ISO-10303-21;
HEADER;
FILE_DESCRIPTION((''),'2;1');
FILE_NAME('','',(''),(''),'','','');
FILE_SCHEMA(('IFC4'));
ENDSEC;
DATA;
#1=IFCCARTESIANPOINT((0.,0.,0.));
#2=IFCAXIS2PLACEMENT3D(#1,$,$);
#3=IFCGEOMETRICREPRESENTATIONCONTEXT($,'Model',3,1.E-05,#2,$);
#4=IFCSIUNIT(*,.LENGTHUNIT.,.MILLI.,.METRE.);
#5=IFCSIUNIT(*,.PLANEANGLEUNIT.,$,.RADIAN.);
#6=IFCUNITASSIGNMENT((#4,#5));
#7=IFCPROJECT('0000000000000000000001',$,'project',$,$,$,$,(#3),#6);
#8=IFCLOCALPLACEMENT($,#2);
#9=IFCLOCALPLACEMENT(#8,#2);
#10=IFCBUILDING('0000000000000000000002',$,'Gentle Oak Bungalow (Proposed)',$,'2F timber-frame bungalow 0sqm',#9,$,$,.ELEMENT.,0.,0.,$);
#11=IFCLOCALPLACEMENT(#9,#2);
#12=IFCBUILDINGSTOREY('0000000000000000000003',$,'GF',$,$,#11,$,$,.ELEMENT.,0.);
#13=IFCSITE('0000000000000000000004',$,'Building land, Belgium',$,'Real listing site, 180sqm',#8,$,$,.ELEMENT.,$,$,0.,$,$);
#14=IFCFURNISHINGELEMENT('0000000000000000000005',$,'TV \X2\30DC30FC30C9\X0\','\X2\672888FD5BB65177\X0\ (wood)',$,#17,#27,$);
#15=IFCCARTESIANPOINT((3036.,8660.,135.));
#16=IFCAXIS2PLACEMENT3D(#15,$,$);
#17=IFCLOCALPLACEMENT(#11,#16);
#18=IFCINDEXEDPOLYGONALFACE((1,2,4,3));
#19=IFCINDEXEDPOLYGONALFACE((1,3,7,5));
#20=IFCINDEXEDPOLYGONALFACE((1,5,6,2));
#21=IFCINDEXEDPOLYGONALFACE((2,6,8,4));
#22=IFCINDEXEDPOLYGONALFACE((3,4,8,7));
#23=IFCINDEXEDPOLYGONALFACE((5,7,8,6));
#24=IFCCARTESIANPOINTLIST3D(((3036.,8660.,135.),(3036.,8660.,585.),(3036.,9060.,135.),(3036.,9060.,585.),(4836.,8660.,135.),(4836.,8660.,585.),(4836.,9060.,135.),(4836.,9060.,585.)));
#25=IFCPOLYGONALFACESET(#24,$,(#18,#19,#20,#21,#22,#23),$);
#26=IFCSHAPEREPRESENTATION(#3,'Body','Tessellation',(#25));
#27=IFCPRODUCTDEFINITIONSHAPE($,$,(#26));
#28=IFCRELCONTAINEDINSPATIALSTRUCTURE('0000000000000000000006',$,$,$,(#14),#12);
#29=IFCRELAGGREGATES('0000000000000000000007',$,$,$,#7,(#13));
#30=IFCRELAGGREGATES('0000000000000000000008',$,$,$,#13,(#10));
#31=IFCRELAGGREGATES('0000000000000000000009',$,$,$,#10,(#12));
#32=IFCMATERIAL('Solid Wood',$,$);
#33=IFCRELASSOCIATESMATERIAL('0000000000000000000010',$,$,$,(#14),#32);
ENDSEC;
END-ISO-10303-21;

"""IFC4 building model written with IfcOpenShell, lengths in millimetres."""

from ifc_helpers import new_model, si_unit, frame, frame_2d, origin, place, context, project, spatial, rectangle, extrude, material, element, save


model = new_model("IFC4")

# Units and contexts
model_context = context("Model", 3, precision=1e-05, world=origin())
ifc_project = project(units=[si_unit("LENGTHUNIT", "METRE", prefix="MILLI"), si_unit("PLANEANGLEUNIT", "RADIAN")], contexts=[model_context])

# Site, building, storey
site_placement = place(None, origin())
site = spatial("IfcSite", under=ifc_project, at=site_placement, Name="Building land, Belgium", ObjectType="Real listing site, 180sqm", CompositionType="ELEMENT", RefElevation=0.0)
building_placement = place(site_placement, origin())
building = spatial("IfcBuilding", under=site, at=building_placement, Name="Gentle Oak Bungalow (Proposed)", ObjectType="2F timber-frame bungalow 0sqm", CompositionType="ELEMENT", ElevationOfRefHeight=0.0, ElevationOfTerrain=0.0)
storey_placement = place(building_placement, origin())
storey = spatial("IfcBuildingStorey", under=building, at=storey_placement, Name="GF", CompositionType="ELEMENT", Elevation=0.0)

# Shared definitions
ifc_material_1 = material(Name="Solid Wood")

# Furnishing element
furnishing_placement = place(storey_placement, frame((3036.0, 8660.0, 135.0)))
element("IfcFurnishingElement", 1, at=furnishing_placement, inside=storey, material=ifc_material_1, Name="TV ボード", Description="木製家具 (wood)", context=model_context, shape_type="SweptSolid", body=[
    extrude(rectangle(XDim=1800.0, YDim=400.0, at=frame_2d((900.0, 200.0))), frame((3036.0, 8660.0, 135.0)), (0.0, 0.0, 1.0), 450.0),
])

save(model, "model.ifc")
